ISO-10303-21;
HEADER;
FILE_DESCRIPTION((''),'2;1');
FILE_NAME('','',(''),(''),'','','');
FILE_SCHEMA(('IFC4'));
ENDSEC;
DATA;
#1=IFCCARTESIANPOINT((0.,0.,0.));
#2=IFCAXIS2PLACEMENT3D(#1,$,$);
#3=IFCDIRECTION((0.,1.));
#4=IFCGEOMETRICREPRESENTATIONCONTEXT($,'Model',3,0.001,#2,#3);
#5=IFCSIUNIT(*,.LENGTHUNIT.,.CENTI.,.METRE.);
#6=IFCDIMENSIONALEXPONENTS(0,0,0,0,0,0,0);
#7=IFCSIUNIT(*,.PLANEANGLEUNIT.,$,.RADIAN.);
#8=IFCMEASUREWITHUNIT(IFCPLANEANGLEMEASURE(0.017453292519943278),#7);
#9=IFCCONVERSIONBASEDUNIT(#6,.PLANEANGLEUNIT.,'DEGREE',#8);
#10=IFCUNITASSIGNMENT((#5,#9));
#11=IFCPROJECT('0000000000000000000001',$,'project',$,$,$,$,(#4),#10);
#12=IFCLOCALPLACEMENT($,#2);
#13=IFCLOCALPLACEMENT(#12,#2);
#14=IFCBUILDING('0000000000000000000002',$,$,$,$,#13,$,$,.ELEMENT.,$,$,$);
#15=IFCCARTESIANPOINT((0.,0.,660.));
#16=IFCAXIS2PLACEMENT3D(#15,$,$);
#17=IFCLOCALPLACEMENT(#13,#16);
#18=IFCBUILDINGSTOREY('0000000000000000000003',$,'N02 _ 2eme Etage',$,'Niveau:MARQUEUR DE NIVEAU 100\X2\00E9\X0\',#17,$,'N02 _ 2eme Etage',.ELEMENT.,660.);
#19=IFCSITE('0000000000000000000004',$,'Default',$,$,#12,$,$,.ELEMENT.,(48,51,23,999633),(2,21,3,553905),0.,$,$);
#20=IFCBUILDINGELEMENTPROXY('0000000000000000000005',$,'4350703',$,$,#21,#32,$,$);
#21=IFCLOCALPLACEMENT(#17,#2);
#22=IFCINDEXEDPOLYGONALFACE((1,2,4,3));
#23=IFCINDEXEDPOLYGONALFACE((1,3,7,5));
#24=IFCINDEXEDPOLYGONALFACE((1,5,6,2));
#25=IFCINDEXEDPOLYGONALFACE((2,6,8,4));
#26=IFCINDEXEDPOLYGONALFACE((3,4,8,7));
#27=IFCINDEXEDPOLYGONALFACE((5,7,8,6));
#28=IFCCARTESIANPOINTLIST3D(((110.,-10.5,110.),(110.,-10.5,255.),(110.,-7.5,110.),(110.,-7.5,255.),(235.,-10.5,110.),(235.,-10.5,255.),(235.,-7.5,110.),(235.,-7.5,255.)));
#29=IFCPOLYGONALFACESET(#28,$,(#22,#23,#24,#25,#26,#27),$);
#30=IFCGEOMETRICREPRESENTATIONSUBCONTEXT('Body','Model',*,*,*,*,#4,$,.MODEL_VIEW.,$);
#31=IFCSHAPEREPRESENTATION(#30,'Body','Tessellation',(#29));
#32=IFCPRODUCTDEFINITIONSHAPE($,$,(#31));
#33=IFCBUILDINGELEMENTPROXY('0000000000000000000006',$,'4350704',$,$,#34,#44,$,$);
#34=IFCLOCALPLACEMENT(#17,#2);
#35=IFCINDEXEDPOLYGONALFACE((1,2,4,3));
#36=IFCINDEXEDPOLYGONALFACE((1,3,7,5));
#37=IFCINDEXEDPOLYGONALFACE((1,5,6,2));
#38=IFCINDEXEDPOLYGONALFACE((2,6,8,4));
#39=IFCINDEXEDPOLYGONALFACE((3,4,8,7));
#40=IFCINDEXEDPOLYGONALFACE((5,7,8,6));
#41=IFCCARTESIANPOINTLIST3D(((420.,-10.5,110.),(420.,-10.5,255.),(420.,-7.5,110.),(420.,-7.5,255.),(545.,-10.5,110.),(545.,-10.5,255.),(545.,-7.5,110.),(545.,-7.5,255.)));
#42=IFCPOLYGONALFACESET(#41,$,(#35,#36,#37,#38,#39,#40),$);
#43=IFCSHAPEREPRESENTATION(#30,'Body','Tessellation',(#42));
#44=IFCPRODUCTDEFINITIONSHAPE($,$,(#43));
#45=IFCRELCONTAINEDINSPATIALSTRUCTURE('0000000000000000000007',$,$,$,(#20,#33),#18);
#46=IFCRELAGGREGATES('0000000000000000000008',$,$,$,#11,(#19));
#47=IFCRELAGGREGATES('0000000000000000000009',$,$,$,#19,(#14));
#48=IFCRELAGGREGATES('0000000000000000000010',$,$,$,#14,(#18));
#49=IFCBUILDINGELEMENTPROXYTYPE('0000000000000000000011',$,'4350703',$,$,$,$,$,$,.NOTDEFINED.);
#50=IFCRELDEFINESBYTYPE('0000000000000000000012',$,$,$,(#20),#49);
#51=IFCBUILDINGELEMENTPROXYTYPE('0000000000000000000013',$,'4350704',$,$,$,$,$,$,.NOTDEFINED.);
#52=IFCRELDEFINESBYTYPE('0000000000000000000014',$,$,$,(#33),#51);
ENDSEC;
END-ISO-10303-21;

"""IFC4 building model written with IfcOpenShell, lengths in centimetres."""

from ifc_helpers import new_model, entity, si_unit, converted_unit, direction, frame, frame_2d, origin, place, context, subcontext, project, spatial, rectangle, extrude, type_object, element, save


model = new_model("IFC4")

# Units and contexts
model_context = context("Model", 3, precision=0.001, world=origin(), true_north=direction((0.0, 1.0)))
body_context = subcontext(model_context, "Body", "Model", "MODEL_VIEW")
ifc_project = project(units=[si_unit("LENGTHUNIT", "METRE", prefix="CENTI"), converted_unit("PLANEANGLEUNIT", "DEGREE", entity("IfcPlaneAngleMeasure", 0.017453292519943278), si_unit("PLANEANGLEUNIT", "RADIAN"), dimensions=[0, 0, 0, 0, 0, 0, 0])], contexts=[model_context])

# Site, building, storey
site_placement = place(None, origin())
site = spatial("IfcSite", under=ifc_project, at=site_placement, Name="Default", CompositionType="ELEMENT", RefLatitude=(48, 51, 23, 999633), RefLongitude=(2, 21, 3, 553905), RefElevation=0.0)
building_placement = place(site_placement, origin())
building = spatial("IfcBuilding", under=site, at=building_placement, CompositionType="ELEMENT")
storey_placement = place(building_placement, frame((0.0, 0.0, 660.0)))
storey = spatial("IfcBuildingStorey", under=building, at=storey_placement, Name="N02 _ 2eme Etage", ObjectType="Niveau:MARQUEUR DE NIVEAU 100é", LongName="N02 _ 2eme Etage", CompositionType="ELEMENT", Elevation=660.0)

# Building element proxies
building_element_proxy_type_1 = type_object("IfcBuildingElementProxyType", Name="4350703", PredefinedType="NOTDEFINED")
proxy_1_placement = place(storey_placement, origin())
element("IfcBuildingElementProxy", 1, at=proxy_1_placement, inside=storey, type_object=building_element_proxy_type_1, Name="4350703", context=body_context, shape_type="SweptSolid", body=[
    extrude(rectangle(XDim=125.0, YDim=3.0, at=frame_2d((0.0, 0.0), x_axis=(1.0, 0.0))), frame((172.5, -9.0, 110.0)), (0.0, 0.0, 1.0), 145.0),
])
building_element_proxy_type_2 = type_object("IfcBuildingElementProxyType", Name="4350704", PredefinedType="NOTDEFINED")
proxy_2_placement = place(storey_placement, origin())
element("IfcBuildingElementProxy", 2, at=proxy_2_placement, inside=storey, type_object=building_element_proxy_type_2, Name="4350704", context=body_context, shape_type="SweptSolid", body=[
    extrude(rectangle(XDim=125.0, YDim=3.0, at=frame_2d((0.0, 0.0), x_axis=(1.0, 0.0))), frame((482.5, -9.0, 110.0)), (0.0, 0.0, 1.0), 145.0),
])

save(model, "model.ifc")
